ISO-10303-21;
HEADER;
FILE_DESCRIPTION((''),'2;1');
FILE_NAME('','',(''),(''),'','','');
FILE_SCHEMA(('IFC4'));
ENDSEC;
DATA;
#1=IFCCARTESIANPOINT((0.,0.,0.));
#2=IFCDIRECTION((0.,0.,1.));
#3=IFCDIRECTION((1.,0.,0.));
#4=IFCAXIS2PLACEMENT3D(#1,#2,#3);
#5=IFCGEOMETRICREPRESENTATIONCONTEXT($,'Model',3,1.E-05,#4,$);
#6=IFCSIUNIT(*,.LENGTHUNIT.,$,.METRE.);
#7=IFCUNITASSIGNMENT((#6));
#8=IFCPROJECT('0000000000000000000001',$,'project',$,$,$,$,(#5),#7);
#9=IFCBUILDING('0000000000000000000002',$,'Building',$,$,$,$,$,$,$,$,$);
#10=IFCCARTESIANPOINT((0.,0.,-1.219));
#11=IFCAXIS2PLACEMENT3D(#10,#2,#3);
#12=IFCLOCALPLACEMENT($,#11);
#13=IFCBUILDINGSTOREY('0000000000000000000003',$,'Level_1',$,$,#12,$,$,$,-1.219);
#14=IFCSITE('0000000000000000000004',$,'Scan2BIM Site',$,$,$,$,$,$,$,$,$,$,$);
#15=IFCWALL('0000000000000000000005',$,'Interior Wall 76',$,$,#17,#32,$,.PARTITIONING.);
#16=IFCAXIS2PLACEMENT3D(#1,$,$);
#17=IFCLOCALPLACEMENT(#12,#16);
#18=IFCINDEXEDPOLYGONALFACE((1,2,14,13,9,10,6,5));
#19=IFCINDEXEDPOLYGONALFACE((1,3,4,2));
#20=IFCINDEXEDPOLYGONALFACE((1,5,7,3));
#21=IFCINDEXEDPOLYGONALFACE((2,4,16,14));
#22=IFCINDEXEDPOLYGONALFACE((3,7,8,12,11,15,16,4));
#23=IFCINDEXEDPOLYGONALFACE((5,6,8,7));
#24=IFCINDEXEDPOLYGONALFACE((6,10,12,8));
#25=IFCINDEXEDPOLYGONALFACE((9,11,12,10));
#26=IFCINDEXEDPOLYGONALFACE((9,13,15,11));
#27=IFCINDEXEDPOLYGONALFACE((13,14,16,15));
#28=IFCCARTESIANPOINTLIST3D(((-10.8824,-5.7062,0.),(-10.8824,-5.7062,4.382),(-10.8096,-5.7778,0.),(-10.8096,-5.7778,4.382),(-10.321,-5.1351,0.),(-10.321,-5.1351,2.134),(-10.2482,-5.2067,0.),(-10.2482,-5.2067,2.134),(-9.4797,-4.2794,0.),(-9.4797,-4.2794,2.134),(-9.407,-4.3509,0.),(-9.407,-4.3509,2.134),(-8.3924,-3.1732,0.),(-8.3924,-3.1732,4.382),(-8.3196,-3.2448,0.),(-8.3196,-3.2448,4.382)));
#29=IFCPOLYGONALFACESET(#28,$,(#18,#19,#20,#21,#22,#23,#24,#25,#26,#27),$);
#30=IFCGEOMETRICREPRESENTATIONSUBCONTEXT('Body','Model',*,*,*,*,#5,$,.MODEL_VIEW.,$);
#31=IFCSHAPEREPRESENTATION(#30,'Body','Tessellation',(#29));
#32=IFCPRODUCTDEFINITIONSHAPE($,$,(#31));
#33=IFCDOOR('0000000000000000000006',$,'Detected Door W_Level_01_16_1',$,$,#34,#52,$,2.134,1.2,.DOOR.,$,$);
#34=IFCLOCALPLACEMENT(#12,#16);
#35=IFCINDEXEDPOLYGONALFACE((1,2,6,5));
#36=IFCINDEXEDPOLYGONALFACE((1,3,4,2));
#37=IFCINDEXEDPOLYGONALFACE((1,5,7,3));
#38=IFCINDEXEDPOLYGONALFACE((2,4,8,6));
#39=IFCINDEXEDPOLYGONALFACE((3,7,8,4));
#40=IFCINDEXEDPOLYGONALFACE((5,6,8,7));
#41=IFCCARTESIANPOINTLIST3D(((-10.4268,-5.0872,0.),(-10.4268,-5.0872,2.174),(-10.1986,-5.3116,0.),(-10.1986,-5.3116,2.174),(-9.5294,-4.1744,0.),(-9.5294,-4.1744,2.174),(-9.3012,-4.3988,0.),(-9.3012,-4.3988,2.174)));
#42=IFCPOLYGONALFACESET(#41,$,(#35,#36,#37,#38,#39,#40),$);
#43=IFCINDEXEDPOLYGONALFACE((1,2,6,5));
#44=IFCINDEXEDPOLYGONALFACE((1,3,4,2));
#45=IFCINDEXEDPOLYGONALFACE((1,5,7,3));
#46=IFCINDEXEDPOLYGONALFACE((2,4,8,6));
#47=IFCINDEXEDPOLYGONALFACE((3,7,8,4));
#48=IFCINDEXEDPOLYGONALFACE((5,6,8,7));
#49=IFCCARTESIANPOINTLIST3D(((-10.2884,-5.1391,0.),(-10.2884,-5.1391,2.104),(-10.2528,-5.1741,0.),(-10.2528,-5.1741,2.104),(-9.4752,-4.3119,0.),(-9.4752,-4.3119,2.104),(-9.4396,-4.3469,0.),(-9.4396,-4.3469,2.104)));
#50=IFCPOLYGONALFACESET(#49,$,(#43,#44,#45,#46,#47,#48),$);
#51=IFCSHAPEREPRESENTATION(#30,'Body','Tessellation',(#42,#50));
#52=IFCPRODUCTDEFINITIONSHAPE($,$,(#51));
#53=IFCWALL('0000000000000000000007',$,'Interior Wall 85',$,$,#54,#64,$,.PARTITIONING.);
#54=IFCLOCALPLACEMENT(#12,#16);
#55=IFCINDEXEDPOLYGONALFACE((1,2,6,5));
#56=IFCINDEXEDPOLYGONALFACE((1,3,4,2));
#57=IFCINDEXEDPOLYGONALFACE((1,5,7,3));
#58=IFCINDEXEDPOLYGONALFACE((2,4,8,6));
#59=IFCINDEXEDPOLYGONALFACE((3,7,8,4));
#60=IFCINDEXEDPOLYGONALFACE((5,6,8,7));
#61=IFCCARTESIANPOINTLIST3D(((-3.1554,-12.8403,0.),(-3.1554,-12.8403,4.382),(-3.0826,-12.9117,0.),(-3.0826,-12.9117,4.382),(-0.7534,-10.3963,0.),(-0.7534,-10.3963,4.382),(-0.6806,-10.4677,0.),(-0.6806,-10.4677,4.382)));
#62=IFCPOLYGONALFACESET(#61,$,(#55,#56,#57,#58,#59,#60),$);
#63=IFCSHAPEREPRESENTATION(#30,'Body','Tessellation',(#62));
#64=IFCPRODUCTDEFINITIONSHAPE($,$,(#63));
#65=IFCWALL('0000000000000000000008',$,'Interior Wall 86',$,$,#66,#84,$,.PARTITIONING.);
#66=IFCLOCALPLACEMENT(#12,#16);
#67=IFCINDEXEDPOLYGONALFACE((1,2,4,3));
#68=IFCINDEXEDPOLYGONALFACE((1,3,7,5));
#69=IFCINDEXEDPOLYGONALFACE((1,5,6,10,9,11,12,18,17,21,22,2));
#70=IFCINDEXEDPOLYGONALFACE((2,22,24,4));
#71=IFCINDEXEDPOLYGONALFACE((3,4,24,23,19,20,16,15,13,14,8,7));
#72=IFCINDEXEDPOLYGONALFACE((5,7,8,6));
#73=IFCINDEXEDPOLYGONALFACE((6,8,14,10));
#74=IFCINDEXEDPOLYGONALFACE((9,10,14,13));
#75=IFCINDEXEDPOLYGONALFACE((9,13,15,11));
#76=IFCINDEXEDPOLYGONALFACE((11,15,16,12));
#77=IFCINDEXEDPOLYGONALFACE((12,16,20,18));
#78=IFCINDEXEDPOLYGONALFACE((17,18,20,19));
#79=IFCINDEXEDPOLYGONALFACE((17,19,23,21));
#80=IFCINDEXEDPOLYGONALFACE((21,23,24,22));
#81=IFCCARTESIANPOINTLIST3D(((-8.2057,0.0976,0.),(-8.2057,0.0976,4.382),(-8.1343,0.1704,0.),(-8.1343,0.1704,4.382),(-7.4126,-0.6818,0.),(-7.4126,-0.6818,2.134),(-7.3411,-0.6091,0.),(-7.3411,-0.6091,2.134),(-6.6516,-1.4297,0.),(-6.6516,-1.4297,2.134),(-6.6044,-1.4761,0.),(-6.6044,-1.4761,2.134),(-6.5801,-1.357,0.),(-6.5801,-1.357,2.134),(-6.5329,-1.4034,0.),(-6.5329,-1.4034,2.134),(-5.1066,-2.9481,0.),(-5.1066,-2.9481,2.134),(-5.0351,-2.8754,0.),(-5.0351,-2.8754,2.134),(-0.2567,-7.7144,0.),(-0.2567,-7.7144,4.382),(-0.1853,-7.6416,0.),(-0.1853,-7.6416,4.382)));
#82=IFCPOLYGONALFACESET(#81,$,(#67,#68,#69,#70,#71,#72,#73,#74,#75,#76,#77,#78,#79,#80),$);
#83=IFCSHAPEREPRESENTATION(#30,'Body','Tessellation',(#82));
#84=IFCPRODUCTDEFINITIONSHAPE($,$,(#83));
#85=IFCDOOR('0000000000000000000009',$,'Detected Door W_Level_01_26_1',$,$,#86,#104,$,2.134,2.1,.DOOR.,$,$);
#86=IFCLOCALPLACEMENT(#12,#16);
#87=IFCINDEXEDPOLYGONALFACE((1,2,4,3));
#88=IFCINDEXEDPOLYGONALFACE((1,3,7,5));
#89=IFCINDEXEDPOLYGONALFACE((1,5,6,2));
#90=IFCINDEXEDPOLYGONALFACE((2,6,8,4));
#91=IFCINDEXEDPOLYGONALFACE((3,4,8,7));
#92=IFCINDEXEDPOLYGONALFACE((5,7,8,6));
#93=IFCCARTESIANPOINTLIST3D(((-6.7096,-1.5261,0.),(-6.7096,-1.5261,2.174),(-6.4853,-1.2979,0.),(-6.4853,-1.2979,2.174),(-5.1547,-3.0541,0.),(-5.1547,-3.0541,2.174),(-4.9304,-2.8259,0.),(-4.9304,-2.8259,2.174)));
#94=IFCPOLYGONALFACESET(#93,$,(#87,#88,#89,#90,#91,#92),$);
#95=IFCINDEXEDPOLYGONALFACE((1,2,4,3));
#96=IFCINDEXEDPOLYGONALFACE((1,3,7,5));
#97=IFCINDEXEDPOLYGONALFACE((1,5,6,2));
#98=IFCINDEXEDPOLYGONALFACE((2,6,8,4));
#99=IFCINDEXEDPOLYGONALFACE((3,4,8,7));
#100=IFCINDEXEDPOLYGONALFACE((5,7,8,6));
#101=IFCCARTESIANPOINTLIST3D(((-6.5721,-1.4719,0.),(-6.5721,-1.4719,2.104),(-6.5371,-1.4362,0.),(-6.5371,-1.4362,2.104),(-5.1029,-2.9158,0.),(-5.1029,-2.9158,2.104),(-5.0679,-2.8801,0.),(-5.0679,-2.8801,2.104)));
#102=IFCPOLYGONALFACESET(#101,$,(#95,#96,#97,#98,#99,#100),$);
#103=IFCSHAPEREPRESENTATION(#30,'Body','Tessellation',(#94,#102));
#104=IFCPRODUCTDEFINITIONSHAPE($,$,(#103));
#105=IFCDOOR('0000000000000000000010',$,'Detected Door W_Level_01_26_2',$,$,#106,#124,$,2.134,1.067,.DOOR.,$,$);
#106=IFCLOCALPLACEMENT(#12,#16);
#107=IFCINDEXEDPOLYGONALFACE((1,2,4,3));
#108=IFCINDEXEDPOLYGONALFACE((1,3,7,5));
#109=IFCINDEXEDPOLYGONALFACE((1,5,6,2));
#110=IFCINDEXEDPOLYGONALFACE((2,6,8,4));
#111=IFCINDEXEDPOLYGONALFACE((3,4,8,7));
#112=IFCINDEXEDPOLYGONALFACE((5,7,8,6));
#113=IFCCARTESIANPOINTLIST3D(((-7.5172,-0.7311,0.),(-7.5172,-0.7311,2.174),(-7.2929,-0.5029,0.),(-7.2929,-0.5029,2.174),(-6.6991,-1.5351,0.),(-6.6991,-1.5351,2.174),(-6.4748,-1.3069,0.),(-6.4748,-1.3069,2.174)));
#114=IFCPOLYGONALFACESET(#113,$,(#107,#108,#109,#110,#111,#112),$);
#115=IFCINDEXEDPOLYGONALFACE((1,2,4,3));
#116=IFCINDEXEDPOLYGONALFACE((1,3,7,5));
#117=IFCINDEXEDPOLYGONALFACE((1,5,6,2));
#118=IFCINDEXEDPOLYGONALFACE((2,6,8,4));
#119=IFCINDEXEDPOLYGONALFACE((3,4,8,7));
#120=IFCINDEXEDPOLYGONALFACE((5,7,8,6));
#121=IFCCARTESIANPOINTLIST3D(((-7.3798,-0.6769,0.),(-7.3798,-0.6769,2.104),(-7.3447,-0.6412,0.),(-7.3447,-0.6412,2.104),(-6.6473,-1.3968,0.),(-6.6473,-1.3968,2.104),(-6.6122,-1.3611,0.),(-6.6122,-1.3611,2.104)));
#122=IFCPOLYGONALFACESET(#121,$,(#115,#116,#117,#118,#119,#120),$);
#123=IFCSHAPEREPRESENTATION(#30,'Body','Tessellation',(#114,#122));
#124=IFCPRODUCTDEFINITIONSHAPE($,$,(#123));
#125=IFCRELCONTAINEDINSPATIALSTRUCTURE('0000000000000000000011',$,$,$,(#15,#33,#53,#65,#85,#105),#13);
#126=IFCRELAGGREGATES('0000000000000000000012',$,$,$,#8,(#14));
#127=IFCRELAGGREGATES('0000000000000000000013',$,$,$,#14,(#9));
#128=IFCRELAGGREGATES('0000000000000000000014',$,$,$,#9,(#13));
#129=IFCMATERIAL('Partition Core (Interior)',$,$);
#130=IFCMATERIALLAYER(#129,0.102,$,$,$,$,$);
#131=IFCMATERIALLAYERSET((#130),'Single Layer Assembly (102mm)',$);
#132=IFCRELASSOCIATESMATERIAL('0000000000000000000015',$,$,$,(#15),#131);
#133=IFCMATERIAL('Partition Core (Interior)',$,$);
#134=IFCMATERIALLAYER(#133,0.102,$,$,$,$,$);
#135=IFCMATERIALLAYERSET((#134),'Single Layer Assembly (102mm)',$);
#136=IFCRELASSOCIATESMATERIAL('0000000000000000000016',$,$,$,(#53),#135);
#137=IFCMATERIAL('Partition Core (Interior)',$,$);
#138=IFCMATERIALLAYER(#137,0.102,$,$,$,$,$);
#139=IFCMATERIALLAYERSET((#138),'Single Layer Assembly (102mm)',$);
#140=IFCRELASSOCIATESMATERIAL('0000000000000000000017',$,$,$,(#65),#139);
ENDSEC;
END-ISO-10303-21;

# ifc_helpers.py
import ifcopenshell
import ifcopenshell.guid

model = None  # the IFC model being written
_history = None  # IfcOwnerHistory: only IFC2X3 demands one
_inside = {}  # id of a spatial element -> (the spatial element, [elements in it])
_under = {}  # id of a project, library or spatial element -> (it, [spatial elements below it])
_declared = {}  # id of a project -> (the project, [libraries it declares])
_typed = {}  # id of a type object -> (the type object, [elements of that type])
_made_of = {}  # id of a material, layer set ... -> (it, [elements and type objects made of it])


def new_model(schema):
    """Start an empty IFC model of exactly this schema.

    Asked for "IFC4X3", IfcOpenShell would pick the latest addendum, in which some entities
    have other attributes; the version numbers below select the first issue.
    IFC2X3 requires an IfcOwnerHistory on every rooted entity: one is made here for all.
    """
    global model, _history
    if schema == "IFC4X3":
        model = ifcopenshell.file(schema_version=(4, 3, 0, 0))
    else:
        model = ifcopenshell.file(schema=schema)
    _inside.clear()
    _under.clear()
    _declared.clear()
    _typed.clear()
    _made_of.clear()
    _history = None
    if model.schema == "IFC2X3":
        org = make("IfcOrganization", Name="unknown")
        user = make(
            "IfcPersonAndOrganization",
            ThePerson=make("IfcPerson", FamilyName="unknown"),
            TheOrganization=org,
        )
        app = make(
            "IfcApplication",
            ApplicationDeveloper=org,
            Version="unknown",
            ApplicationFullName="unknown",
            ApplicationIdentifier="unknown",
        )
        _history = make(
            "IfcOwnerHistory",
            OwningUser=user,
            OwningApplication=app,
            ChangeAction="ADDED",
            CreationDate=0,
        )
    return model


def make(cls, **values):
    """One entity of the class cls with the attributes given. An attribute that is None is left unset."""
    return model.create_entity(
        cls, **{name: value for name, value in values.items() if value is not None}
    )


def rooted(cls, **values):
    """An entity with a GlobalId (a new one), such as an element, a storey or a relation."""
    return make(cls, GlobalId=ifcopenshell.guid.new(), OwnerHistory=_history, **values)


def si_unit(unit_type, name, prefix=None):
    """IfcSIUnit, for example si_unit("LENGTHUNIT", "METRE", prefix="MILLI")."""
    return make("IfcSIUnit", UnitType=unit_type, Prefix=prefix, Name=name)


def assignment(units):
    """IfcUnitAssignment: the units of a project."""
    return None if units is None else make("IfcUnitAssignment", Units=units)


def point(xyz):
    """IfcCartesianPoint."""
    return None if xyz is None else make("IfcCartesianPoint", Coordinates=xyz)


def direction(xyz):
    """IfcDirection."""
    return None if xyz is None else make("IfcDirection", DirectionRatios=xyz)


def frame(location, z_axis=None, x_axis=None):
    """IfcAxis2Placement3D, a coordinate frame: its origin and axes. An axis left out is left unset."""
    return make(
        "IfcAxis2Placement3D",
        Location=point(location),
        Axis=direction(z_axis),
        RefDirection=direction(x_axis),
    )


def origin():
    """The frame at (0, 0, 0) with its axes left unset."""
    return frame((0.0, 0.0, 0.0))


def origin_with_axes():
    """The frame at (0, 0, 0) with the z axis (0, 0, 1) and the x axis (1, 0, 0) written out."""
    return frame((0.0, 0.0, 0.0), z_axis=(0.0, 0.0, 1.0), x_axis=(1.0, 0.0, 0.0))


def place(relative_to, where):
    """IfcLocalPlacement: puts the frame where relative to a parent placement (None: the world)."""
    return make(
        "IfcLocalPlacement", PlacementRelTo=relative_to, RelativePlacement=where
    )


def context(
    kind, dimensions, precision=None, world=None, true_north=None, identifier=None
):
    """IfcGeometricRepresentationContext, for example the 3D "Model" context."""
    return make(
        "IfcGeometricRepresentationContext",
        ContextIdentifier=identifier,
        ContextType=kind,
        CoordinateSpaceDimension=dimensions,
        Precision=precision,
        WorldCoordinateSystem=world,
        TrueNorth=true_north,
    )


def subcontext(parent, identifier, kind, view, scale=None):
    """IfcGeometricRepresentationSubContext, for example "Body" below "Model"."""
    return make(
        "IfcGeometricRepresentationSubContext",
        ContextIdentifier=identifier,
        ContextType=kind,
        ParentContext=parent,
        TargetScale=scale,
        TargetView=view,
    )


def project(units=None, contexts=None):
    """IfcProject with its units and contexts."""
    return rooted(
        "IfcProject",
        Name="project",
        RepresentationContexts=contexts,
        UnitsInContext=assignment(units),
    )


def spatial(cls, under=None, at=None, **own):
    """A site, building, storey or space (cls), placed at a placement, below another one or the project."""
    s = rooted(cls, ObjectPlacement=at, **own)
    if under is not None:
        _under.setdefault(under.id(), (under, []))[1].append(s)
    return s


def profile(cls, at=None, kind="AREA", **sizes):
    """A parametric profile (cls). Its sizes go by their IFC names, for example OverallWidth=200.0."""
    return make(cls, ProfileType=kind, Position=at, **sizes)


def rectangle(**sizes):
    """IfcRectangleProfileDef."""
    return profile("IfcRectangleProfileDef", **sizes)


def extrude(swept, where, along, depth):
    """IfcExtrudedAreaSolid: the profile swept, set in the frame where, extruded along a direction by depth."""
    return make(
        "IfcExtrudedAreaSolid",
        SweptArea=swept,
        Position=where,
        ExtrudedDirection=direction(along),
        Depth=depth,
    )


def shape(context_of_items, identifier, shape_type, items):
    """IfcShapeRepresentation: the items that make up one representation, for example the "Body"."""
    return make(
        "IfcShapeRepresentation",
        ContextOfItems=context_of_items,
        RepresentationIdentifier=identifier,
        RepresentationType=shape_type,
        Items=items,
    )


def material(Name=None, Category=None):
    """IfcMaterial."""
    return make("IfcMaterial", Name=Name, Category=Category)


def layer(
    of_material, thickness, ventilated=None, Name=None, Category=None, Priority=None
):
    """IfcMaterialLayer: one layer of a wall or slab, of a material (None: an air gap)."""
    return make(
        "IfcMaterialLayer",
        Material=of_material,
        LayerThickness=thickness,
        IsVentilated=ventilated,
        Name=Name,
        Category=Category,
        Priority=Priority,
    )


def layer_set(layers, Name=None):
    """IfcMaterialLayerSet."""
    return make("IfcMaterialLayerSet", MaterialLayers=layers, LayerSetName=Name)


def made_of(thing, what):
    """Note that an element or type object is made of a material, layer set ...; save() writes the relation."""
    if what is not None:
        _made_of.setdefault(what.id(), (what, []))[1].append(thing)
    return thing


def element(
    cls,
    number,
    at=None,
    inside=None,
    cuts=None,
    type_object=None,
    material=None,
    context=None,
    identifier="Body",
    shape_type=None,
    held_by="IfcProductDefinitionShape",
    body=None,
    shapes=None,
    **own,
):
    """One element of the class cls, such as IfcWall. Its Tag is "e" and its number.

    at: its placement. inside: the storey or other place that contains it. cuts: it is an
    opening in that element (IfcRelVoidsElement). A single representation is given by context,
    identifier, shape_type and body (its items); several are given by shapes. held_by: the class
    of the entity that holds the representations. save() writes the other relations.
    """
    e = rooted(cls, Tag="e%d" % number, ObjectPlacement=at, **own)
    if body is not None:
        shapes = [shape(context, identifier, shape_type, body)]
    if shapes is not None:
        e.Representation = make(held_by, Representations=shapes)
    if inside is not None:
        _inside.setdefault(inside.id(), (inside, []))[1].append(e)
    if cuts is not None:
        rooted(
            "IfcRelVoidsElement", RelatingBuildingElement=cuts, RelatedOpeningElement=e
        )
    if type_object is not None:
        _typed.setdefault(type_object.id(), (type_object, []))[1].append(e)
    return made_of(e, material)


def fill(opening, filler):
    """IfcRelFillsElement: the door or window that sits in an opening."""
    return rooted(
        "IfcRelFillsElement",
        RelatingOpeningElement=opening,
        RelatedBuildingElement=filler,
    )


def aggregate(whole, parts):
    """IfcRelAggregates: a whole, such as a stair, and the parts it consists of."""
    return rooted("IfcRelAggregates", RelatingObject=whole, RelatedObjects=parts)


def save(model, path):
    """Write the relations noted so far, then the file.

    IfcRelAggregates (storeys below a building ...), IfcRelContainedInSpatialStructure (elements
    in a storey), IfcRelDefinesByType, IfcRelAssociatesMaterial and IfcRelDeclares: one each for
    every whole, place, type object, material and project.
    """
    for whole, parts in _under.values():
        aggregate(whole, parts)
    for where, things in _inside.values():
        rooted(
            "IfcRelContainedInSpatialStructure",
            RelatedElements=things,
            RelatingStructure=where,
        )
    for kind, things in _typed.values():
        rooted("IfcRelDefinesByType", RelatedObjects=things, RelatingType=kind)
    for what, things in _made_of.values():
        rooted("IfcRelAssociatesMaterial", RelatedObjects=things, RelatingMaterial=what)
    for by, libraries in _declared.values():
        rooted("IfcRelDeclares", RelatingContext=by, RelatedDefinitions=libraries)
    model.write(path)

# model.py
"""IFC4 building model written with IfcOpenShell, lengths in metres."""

from ifc_helpers import new_model, si_unit, frame, origin, origin_with_axes, place, context, subcontext, project, spatial, rectangle, extrude, material, layer, layer_set, element, fill, save


model = new_model("IFC4")

# Units and contexts
model_context = context("Model", 3, precision=1e-05, world=origin_with_axes())
body_context = subcontext(model_context, "Body", "Model", "MODEL_VIEW")
ifc_project = project(units=[si_unit("LENGTHUNIT", "METRE")], contexts=[model_context])

# Site, building, storey
site = spatial("IfcSite", under=ifc_project, Name="Scan2BIM Site")
building = spatial("IfcBuilding", under=site, Name="Building")
storey_placement = place(None, frame((0.0, 0.0, -1.219), z_axis=(0.0, 0.0, 1.0), x_axis=(1.0, 0.0, 0.0)))
storey = spatial("IfcBuildingStorey", under=building, at=storey_placement, Name="Level_1", Elevation=-1.219)

# Wall, opening, door
ifc_material_1 = material(Name="Partition Core (Interior)")
ifc_layer_1 = layer(ifc_material_1, 0.102)
ifc_layer_set_1 = layer_set([ifc_layer_1], Name="Single Layer Assembly (102mm)")
wall_1_placement = place(storey_placement, frame((-9.601, -4.4755, 0.0), z_axis=(0.0, 0.0, 1.0), x_axis=(0.701028, 0.713134, 0.0)))
wall_1 = element("IfcWall", 1, at=wall_1_placement, inside=storey, material=ifc_layer_set_1, Name="Interior Wall 76", PredefinedType="PARTITIONING", context=body_context, shape_type="SweptSolid", body=[
    extrude(rectangle(XDim=3.5519, YDim=0.102), origin(), (0.0, 0.0, 1.0), 4.382),
])
opening_1_placement = place(None, frame((-9.864, -4.743, -1.219), z_axis=(0.0, 0.0, 1.0), x_axis=(0.701028, 0.713134, 0.0)))
opening_1 = element("IfcOpeningElement", 2, at=opening_1_placement, cuts=wall_1, PredefinedType="OPENING", context=body_context, shape_type="SweptSolid", body=[
    extrude(rectangle(XDim=1.2, YDim=0.202), origin(), (0.0, 0.0, 1.0), 2.134),
])
door_1_placement = place(opening_1_placement, frame((0.0, 0.0, 0.0), z_axis=(0.0, 0.0, 1.0), x_axis=(1.0, 0.0, 0.0)))
door_1 = element("IfcDoor", 3, at=door_1_placement, inside=storey, Name="Detected Door W_Level_01_16_1", OverallHeight=2.134, OverallWidth=1.2, PredefinedType="DOOR", context=body_context, shape_type="SweptSolid", body=[
    extrude(rectangle(XDim=1.28, YDim=0.32), origin(), (0.0, 0.0, 1.0), 2.174),
    extrude(rectangle(XDim=1.16, YDim=0.05), origin(), (0.0, 0.0, 1.0), 2.104),
])
fill(opening_1, door_1)

# Wall
ifc_material_2 = material(Name="Partition Core (Interior)")
ifc_layer_2 = layer(ifc_material_2, 0.102)
ifc_layer_set_2 = layer_set([ifc_layer_2], Name="Single Layer Assembly (102mm)")
wall_2_placement = place(storey_placement, frame((-1.918, -11.654, 0.0), z_axis=(0.0, 0.0, 1.0), x_axis=(-0.700952, -0.713208, 0.0)))
element("IfcWall", 4, at=wall_2_placement, inside=storey, material=ifc_layer_set_2, Name="Interior Wall 85", PredefinedType="PARTITIONING", context=body_context, shape_type="SweptSolid", body=[
    extrude(rectangle(XDim=3.4268, YDim=0.102), origin(), (0.0, 0.0, 1.0), 4.382),
])

# Wall, openings, doors
ifc_material_3 = material(Name="Partition Core (Interior)")
ifc_layer_3 = layer(ifc_material_3, 0.102)
ifc_layer_set_3 = layer_set([ifc_layer_3], Name="Single Layer Assembly (102mm)")
wall_3_placement = place(storey_placement, frame((-4.1955, -3.772, 0.0), z_axis=(0.0, 0.0, 1.0), x_axis=(-0.713226, 0.700934, 0.0)))
wall_3 = element("IfcWall", 5, at=wall_3_placement, inside=storey, material=ifc_layer_set_3, Name="Interior Wall 86", PredefinedType="PARTITIONING", context=body_context, shape_type="SweptSolid", body=[
    extrude(rectangle(XDim=11.1451, YDim=0.102), origin(), (0.0, 0.0, 1.0), 4.382),
])
opening_2_placement = place(None, frame((-5.82, -2.176, -1.219), z_axis=(0.0, 0.0, 1.0), x_axis=(-0.713226, 0.700934, 0.0)))
opening_2 = element("IfcOpeningElement", 6, at=opening_2_placement, cuts=wall_3, PredefinedType="OPENING", context=body_context, shape_type="SweptSolid", body=[
    extrude(rectangle(XDim=2.1, YDim=0.202), origin(), (0.0, 0.0, 1.0), 2.134),
])
opening_3_placement = place(None, frame((-6.996, -1.019, -1.219), z_axis=(0.0, 0.0, 1.0), x_axis=(-0.713226, 0.700934, 0.0)))
opening_3 = element("IfcOpeningElement", 7, at=opening_3_placement, cuts=wall_3, PredefinedType="OPENING", context=body_context, shape_type="SweptSolid", body=[
    extrude(rectangle(XDim=1.067, YDim=0.202), origin(), (0.0, 0.0, 1.0), 2.134),
])
door_2_placement = place(opening_2_placement, frame((0.0, 0.0, 0.0), z_axis=(0.0, 0.0, 1.0), x_axis=(1.0, 0.0, 0.0)))
door_2 = element("IfcDoor", 8, at=door_2_placement, inside=storey, Name="Detected Door W_Level_01_26_1", OverallHeight=2.134, OverallWidth=2.1, PredefinedType="DOOR", context=body_context, shape_type="SweptSolid", body=[
    extrude(rectangle(XDim=2.18, YDim=0.32), origin(), (0.0, 0.0, 1.0), 2.174),
    extrude(rectangle(XDim=2.06, YDim=0.05), origin(), (0.0, 0.0, 1.0), 2.104),
])
fill(opening_2, door_2)
door_3_placement = place(opening_3_placement, frame((0.0, 0.0, 0.0), z_axis=(0.0, 0.0, 1.0), x_axis=(1.0, 0.0, 0.0)))
door_3 = element("IfcDoor", 9, at=door_3_placement, inside=storey, Name="Detected Door W_Level_01_26_2", OverallHeight=2.134, OverallWidth=1.067, PredefinedType="DOOR", context=body_context, shape_type="SweptSolid", body=[
    extrude(rectangle(XDim=1.147, YDim=0.32), origin(), (0.0, 0.0, 1.0), 2.174),
    extrude(rectangle(XDim=1.027, YDim=0.05), origin(), (0.0, 0.0, 1.0), 2.104),
])
fill(opening_3, door_3)

save(model, "model.ifc")
